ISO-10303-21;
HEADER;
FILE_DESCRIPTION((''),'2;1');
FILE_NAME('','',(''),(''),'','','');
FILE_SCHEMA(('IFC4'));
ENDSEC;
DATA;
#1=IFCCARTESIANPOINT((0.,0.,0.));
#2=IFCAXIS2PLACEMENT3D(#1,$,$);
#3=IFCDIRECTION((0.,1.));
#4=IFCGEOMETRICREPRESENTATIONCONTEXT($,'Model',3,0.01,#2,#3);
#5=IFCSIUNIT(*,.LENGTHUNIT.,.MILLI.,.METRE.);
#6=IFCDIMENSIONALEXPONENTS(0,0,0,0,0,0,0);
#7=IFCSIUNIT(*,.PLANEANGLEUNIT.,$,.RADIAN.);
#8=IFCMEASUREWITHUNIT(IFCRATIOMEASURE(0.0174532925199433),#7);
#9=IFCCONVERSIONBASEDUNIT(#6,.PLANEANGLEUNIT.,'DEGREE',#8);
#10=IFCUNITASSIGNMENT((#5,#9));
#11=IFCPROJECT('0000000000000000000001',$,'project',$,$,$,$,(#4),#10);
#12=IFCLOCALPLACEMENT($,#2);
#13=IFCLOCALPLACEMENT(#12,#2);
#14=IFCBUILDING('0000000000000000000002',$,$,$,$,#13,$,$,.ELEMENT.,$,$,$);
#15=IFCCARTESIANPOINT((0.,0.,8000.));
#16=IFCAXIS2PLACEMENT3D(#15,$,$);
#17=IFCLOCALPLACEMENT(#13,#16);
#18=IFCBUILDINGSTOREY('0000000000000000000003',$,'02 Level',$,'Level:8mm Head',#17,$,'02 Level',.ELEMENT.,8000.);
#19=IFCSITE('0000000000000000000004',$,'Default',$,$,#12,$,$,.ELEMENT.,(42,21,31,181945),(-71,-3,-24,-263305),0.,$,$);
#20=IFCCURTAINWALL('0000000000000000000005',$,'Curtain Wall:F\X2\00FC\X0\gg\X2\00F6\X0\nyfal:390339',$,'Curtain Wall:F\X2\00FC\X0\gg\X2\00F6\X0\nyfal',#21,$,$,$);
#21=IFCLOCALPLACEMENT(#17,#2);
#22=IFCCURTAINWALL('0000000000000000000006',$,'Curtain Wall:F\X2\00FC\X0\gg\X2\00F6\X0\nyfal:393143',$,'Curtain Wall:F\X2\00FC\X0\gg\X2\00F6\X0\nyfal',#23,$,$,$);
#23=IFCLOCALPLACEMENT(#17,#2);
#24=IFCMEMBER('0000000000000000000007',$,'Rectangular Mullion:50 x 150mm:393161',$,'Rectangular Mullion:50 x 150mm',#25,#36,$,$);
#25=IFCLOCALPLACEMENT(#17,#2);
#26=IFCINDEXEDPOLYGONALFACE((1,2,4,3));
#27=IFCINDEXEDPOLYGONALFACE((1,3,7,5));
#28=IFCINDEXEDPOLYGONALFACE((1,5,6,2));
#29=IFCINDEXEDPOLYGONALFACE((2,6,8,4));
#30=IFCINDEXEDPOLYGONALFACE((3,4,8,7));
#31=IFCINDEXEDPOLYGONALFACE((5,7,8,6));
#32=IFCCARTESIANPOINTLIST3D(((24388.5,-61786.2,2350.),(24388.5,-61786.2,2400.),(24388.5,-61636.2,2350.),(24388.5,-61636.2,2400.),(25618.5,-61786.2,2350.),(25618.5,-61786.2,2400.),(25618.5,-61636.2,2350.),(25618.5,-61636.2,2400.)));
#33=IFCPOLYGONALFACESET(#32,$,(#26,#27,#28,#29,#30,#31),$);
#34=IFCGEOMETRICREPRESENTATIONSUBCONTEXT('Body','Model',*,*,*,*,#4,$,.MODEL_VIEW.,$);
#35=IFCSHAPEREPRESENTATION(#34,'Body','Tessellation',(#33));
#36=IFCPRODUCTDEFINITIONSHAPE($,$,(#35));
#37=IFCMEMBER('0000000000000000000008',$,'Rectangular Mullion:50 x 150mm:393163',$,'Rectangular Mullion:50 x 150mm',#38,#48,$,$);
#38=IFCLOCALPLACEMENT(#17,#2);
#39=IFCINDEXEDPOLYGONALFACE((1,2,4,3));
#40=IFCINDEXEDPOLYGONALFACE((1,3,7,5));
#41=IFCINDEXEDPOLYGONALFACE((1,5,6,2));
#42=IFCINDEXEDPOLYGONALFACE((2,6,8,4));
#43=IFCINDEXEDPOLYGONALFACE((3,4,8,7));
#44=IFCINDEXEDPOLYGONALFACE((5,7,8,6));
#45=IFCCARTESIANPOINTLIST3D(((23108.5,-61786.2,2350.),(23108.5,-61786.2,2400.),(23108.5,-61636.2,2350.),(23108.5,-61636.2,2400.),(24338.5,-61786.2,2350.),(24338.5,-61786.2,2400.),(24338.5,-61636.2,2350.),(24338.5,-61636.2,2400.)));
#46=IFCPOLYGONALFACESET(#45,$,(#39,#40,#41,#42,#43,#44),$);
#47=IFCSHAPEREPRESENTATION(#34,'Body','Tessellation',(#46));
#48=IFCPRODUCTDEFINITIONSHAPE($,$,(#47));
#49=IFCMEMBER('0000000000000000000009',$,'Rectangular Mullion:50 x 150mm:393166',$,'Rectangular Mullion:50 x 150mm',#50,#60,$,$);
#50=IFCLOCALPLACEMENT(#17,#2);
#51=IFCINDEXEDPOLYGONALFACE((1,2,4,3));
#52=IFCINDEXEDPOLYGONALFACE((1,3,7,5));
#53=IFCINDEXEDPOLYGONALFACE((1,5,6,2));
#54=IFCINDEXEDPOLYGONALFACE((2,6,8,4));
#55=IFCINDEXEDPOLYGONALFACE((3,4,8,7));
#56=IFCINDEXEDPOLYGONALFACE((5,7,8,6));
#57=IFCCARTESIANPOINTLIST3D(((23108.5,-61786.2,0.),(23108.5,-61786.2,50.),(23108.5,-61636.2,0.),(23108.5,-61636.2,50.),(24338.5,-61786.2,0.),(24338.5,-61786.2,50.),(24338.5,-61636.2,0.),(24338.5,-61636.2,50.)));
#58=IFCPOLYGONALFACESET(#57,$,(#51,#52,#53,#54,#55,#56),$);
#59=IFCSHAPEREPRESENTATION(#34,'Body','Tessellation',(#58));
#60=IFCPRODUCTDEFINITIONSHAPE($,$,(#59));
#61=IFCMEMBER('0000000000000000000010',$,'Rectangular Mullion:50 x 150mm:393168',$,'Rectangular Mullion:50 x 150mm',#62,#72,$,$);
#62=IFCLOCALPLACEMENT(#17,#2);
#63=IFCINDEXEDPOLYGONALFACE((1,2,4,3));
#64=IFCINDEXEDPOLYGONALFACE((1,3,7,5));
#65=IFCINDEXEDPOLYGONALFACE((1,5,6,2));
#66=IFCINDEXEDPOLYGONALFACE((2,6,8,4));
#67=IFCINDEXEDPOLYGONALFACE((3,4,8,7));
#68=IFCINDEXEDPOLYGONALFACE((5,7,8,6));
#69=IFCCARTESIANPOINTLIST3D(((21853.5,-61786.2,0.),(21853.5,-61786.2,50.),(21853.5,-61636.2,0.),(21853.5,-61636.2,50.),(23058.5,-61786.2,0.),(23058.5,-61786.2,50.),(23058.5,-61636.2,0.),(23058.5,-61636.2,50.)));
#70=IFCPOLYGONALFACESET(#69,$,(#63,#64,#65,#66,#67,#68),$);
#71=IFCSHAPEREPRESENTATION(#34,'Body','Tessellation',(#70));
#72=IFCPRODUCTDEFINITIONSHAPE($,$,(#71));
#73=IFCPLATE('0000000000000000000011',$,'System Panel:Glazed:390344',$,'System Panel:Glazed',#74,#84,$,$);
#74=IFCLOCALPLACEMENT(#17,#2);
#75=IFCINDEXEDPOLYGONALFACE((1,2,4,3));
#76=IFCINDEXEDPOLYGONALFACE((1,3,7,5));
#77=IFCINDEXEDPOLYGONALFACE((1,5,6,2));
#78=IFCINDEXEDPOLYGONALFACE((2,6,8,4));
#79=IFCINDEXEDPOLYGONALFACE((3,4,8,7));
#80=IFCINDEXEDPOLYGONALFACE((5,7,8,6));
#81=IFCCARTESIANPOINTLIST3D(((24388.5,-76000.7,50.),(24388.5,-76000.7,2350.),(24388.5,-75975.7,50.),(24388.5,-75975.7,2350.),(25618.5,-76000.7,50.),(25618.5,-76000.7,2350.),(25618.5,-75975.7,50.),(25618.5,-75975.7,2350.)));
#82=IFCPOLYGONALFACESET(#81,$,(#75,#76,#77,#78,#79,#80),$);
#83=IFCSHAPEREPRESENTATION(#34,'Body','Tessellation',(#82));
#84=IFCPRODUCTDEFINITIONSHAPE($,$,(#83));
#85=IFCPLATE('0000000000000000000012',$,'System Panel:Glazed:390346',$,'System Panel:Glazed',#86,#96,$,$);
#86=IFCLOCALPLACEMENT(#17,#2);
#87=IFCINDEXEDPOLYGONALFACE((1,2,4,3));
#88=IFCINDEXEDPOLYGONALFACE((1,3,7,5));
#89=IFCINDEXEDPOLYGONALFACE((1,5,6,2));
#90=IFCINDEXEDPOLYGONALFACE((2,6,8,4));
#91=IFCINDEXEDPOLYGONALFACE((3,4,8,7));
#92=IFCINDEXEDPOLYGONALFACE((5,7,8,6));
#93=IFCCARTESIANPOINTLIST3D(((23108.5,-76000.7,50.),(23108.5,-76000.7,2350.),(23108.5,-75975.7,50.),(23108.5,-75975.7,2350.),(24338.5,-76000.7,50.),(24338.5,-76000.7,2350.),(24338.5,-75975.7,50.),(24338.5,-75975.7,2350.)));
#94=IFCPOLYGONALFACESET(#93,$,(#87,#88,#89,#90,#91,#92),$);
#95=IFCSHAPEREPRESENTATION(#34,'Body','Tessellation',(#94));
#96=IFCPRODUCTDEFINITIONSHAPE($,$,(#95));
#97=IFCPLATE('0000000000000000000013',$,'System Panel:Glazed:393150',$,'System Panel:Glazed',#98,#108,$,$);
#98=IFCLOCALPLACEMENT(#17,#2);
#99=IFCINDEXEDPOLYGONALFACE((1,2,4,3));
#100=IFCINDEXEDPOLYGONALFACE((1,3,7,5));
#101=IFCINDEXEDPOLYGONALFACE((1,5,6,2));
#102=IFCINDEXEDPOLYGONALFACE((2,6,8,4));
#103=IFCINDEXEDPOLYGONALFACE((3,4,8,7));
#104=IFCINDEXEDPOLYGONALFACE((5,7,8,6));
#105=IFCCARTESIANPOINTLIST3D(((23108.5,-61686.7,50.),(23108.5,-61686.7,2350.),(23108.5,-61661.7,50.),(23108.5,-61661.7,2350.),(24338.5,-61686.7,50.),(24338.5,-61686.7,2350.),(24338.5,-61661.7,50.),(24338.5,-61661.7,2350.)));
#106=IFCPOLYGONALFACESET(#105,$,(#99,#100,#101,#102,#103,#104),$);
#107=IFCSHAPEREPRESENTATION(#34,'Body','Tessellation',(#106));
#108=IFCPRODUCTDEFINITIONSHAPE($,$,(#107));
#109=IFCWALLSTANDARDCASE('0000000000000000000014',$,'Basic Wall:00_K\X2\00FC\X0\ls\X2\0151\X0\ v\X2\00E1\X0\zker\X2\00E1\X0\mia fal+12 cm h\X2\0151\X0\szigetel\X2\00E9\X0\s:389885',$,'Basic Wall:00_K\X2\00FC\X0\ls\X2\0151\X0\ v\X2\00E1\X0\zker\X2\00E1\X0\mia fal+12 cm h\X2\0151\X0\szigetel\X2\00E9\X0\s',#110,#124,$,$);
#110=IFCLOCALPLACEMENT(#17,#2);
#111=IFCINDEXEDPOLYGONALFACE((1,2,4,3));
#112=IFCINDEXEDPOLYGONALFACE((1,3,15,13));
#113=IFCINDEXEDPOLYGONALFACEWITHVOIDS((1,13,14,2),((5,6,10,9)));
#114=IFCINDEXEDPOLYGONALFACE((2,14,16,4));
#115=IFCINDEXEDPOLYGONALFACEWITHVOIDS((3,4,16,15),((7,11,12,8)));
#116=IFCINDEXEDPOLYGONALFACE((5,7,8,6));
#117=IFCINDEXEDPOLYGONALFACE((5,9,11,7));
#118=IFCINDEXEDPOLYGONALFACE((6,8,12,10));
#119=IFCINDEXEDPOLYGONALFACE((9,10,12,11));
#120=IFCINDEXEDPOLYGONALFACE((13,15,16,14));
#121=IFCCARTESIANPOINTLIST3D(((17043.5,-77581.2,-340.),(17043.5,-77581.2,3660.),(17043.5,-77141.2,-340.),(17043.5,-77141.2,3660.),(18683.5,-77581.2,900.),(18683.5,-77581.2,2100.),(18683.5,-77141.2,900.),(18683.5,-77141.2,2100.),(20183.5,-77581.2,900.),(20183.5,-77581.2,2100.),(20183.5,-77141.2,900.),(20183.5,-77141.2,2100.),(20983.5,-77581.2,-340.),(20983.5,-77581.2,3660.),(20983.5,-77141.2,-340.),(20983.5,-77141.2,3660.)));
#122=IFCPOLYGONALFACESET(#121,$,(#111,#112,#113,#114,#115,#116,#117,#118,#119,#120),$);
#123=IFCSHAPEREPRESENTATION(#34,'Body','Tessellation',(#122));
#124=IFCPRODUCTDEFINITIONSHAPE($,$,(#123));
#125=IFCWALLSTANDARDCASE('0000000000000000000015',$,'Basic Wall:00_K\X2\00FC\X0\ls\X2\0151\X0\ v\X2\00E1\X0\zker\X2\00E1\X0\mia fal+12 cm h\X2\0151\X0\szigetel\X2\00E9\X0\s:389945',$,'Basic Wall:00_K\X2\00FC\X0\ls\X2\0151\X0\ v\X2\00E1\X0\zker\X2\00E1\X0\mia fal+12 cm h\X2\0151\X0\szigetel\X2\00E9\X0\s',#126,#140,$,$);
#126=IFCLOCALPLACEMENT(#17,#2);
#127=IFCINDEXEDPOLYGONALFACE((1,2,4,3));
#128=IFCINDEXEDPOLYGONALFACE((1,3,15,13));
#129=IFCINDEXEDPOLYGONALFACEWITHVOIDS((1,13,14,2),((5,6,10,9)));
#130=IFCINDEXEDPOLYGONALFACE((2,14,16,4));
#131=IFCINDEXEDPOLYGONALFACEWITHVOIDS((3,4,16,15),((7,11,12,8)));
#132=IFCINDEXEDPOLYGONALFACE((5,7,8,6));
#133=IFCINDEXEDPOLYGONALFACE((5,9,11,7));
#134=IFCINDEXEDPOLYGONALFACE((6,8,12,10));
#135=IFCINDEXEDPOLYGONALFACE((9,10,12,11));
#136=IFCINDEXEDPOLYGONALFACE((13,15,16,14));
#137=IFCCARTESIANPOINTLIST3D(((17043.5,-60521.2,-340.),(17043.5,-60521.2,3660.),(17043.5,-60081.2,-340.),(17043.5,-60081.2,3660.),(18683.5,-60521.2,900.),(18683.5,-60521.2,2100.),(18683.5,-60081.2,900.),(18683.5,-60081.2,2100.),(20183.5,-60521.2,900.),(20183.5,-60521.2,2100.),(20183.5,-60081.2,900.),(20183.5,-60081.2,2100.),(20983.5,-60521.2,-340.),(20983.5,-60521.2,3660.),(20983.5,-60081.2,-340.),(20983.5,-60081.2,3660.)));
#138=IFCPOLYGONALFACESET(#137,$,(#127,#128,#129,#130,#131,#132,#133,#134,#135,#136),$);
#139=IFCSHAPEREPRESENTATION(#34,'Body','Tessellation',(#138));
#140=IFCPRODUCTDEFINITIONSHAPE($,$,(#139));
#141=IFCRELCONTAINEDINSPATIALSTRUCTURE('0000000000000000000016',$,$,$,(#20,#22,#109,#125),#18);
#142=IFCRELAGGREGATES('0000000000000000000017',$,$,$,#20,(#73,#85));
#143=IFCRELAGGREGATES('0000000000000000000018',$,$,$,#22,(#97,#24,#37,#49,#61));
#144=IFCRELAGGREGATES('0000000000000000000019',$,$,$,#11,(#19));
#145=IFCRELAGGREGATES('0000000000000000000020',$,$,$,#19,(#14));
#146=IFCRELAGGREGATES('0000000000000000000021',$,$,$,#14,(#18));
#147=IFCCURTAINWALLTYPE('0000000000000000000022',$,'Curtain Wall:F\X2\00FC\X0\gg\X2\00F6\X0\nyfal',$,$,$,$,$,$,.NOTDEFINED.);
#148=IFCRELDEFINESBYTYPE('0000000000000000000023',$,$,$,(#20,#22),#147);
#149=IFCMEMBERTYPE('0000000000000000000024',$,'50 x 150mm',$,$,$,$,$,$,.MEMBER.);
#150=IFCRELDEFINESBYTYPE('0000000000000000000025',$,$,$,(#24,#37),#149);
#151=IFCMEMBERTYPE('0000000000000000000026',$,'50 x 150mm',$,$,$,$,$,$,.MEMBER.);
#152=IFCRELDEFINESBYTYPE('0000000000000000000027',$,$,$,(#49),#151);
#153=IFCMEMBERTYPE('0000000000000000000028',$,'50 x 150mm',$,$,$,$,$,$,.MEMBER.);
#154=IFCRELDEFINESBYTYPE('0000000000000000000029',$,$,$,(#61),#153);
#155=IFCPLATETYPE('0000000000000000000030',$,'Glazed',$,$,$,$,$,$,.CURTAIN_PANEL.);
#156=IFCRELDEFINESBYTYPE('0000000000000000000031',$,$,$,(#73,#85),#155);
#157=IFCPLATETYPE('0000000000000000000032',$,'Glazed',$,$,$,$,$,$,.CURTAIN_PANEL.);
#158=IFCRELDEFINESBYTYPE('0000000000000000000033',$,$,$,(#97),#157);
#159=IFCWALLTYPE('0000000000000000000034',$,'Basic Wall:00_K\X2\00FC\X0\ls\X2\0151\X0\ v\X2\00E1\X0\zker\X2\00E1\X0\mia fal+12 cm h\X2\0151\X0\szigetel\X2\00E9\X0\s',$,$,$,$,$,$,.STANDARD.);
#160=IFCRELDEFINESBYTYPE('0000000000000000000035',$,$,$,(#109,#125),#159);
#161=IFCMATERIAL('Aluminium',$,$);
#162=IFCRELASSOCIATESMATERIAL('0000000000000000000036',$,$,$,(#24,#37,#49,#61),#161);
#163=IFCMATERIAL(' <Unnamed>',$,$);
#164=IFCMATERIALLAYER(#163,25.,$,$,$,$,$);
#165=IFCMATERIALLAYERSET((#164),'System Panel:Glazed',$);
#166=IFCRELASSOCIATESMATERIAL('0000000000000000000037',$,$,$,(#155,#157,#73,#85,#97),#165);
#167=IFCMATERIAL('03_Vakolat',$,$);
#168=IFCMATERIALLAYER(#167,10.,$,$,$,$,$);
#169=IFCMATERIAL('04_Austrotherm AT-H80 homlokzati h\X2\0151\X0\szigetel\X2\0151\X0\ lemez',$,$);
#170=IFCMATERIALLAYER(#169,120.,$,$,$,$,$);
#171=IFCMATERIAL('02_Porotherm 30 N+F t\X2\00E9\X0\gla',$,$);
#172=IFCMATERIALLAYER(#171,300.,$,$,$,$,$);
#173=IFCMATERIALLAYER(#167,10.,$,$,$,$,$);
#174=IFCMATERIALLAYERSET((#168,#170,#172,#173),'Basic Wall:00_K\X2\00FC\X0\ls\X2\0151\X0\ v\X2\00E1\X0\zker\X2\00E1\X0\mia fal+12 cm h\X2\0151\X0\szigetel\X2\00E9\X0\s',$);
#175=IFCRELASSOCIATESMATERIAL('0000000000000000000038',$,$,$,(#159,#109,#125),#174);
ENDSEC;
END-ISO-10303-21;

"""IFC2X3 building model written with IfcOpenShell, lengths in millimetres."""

from ifc_helpers import new_model, entity, si_unit, converted_unit, direction, frame, frame_2d, origin, origin_2d_with_axis, place, context, subcontext, project, spatial, rectangle, extrude, source, transform, mapped, material, layer, layer_set, layer_usage, type_object, type_shapes, element, aggregate, save


model = new_model("IFC2X3")

# Units and contexts
model_context = context("Model", 3, precision=0.01, world=origin(), true_north=direction((0.0, 1.0)))
body_context = subcontext(model_context, "Body", "Model", "MODEL_VIEW")
ifc_project = project(units=[si_unit("LENGTHUNIT", "METRE", prefix="MILLI"), converted_unit("PLANEANGLEUNIT", "DEGREE", entity("IfcRatioMeasure", 0.0174532925199433), si_unit("PLANEANGLEUNIT", "RADIAN"), dimensions=[0, 0, 0, 0, 0, 0, 0])], contexts=[model_context])

# Site, building, storey
site_placement = place(None, origin())
site = spatial("IfcSite", under=ifc_project, at=site_placement, Name="Default", CompositionType="ELEMENT", RefLatitude=(42, 21, 31, 181945), RefLongitude=(-71, -3, -24, -263305), RefElevation=0.0)
building_placement = place(site_placement, origin())
building = spatial("IfcBuilding", under=site, at=building_placement, CompositionType="ELEMENT")
storey_placement = place(building_placement, frame((0.0, 0.0, 8000.0)))
storey = spatial("IfcBuildingStorey", under=building, at=storey_placement, Name="02 Level", ObjectType="Level:8mm Head", LongName="02 Level", CompositionType="ELEMENT", Elevation=8000.0)

# Curtain walls, members
curtain_wall_type = type_object("IfcCurtainWallType", Name="Curtain Wall:Függönyfal", PredefinedType="NOTDEFINED")
curtain_wall_1_placement = place(storey_placement, frame((0.0, 0.0, -8000.0)))
curtain_wall_1 = element("IfcCurtainWall", 1, at=curtain_wall_1_placement, inside=storey, type_object=curtain_wall_type, Name="Curtain Wall:Függönyfal:390339", ObjectType="Curtain Wall:Függönyfal")
ifc_material_1 = material(Name="Aluminium")
curtain_wall_2_placement = place(storey_placement, frame((0.0, 0.0, -8000.0)))
curtain_wall_2 = element("IfcCurtainWall", 2, at=curtain_wall_2_placement, inside=storey, type_object=curtain_wall_type, Name="Curtain Wall:Függönyfal:393143", ObjectType="Curtain Wall:Függönyfal")
member_type_1 = type_object("IfcMemberType", Name="50 x 150mm", PredefinedType="MEMBER")
shared_shape_1 = source(origin(), body_context, "Body", "SweptSolid", [
    extrude(rectangle(XDim=150.0, YDim=50.0, at=origin_2d_with_axis()), frame((-25.0, 0.0, -1230.0), z_axis=(0.0, 0.0, 1.0), x_axis=(0.0, -1.0, 0.0)), (0.0, 0.0, 1.0), 1230.0),
])
type_shapes(member_type_1, [shared_shape_1])
member_1_placement = place(storey_placement, frame((24388.5, -61711.2, 2400.0), z_axis=(-1.0, 0.0, 0.0), x_axis=(0.0, 0.0, 1.0)))
member_1 = element("IfcMember", 3, at=member_1_placement, type_object=member_type_1, material=ifc_material_1, Name="Rectangular Mullion:50 x 150mm:393161", ObjectType="Rectangular Mullion:50 x 150mm", context=body_context, shape_type="MappedRepresentation", body=[
    mapped(shared_shape_1, transform((0.0, 0.0, 0.0), scale=1.0)),
])
member_2_placement = place(storey_placement, frame((23108.5, -61711.2, 2400.0), z_axis=(-1.0, 0.0, 0.0), x_axis=(0.0, 0.0, 1.0)))
member_2 = element("IfcMember", 4, at=member_2_placement, type_object=member_type_1, material=ifc_material_1, Name="Rectangular Mullion:50 x 150mm:393163", ObjectType="Rectangular Mullion:50 x 150mm", context=body_context, shape_type="MappedRepresentation", body=[
    mapped(shared_shape_1, transform((0.0, 0.0, 0.0), scale=1.0)),
])
member_type_2 = type_object("IfcMemberType", Name="50 x 150mm", PredefinedType="MEMBER")
shared_shape_2 = source(origin(), body_context, "Body", "SweptSolid", [
    extrude(rectangle(XDim=150.0, YDim=50.0, at=origin_2d_with_axis()), frame((-25.0, 0.0, -1230.0), z_axis=(0.0, 0.0, 1.0), x_axis=(0.0, -1.0, 0.0)), (0.0, 0.0, 1.0), 1230.0),
])
type_shapes(member_type_2, [shared_shape_2])
member_3_placement = place(storey_placement, frame((24338.5, -61711.2, 0.0), z_axis=(1.0, 0.0, 0.0), x_axis=(0.0, 0.0, -1.0)))
member_3 = element("IfcMember", 5, at=member_3_placement, type_object=member_type_2, material=ifc_material_1, Name="Rectangular Mullion:50 x 150mm:393166", ObjectType="Rectangular Mullion:50 x 150mm", context=body_context, shape_type="MappedRepresentation", body=[
    mapped(shared_shape_2, transform((0.0, 0.0, 0.0), scale=1.0)),
])
member_type_3 = type_object("IfcMemberType", Name="50 x 150mm", PredefinedType="MEMBER")
shared_shape_3 = source(origin(), body_context, "Body", "SweptSolid", [
    extrude(rectangle(XDim=150.0, YDim=50.0, at=origin_2d_with_axis()), frame((-25.0, 0.0, -1205.0), z_axis=(0.0, 0.0, 1.0), x_axis=(0.0, -1.0, 0.0)), (0.0, 0.0, 1.0), 1205.0),
])
type_shapes(member_type_3, [shared_shape_3])
member_4_placement = place(storey_placement, frame((23058.5, -61711.2, 0.0), z_axis=(1.0, 0.0, 0.0), x_axis=(0.0, 0.0, -1.0)))
member_4 = element("IfcMember", 6, at=member_4_placement, type_object=member_type_3, material=ifc_material_1, Name="Rectangular Mullion:50 x 150mm:393168", ObjectType="Rectangular Mullion:50 x 150mm", context=body_context, shape_type="MappedRepresentation", body=[
    mapped(shared_shape_3, transform((0.0, 0.0, 0.0), scale=1.0)),
])

# Plates
ifc_material_2 = material(Name=" <Unnamed>")
ifc_layer_1 = layer(ifc_material_2, 25.0)
ifc_layer_set_1 = layer_set([ifc_layer_1], Name="System Panel:Glazed")
ifc_layer_usage_1 = layer_usage(ifc_layer_set_1, "AXIS3", "POSITIVE", 0.1)
plate_type_1 = type_object("IfcPlateType", Name="Glazed", PredefinedType="CURTAIN_PANEL", material=ifc_layer_set_1)
shared_shape_4 = source(origin(), body_context, "Body", "SweptSolid", [
    extrude(rectangle(XDim=25.0, YDim=1230.0, at=origin_2d_with_axis()), frame((615.0, 12.5, 0.0), z_axis=(0.0, 0.0, 1.0), x_axis=(0.0, 1.0, 0.0)), (0.0, 0.0, 1.0), 2300.0),
])
type_shapes(plate_type_1, [shared_shape_4])
plate_1_placement = place(curtain_wall_1_placement, frame((25618.5, -75975.7, 8050.0), z_axis=(0.0, 0.0, 1.0), x_axis=(-1.0, 0.0, 0.0)))
plate_1 = element("IfcPlate", 7, at=plate_1_placement, type_object=plate_type_1, material=ifc_layer_usage_1, Name="System Panel:Glazed:390344", ObjectType="System Panel:Glazed", context=body_context, shape_type="MappedRepresentation", body=[
    mapped(shared_shape_4, transform((0.0, 0.0, 0.0), scale=1.0)),
])
ifc_layer_usage_2 = layer_usage(ifc_layer_set_1, "AXIS3", "POSITIVE", 0.1)
plate_2_placement = place(curtain_wall_1_placement, frame((24338.5, -75975.7, 8050.0), z_axis=(0.0, 0.0, 1.0), x_axis=(-1.0, 0.0, 0.0)))
plate_2 = element("IfcPlate", 8, at=plate_2_placement, type_object=plate_type_1, material=ifc_layer_usage_2, Name="System Panel:Glazed:390346", ObjectType="System Panel:Glazed", context=body_context, shape_type="MappedRepresentation", body=[
    mapped(shared_shape_4, transform((0.0, 0.0, 0.0), scale=1.0)),
])
ifc_layer_usage_3 = layer_usage(ifc_layer_set_1, "AXIS3", "POSITIVE", 0.1)
plate_type_2 = type_object("IfcPlateType", Name="Glazed", PredefinedType="CURTAIN_PANEL", material=ifc_layer_set_1)
shared_shape_5 = source(origin(), body_context, "Body", "SweptSolid", [
    extrude(rectangle(XDim=25.0, YDim=1230.0, at=frame_2d((0.0, 0.0), x_axis=(1.0, 0.0))), frame((615.0, 12.5, 0.0), z_axis=(0.0, 0.0, 1.0), x_axis=(0.0, 1.0, 0.0)), (0.0, 0.0, 1.0), 2300.0),
])
type_shapes(plate_type_2, [shared_shape_5])
plate_3_placement = place(curtain_wall_2_placement, frame((24338.5, -61661.7, 8050.0), z_axis=(0.0, 0.0, 1.0), x_axis=(-1.0, 0.0, 0.0)))
plate_3 = element("IfcPlate", 9, at=plate_3_placement, type_object=plate_type_2, material=ifc_layer_usage_3, Name="System Panel:Glazed:393150", ObjectType="System Panel:Glazed", context=body_context, shape_type="MappedRepresentation", body=[
    mapped(shared_shape_5, transform((0.0, 0.0, 0.0), scale=1.0)),
])

# Walls, openings
ifc_material_3 = material(Name="03_Vakolat")
ifc_layer_2 = layer(ifc_material_3, 10.0)
ifc_material_4 = material(Name="04_Austrotherm AT-H80 homlokzati hőszigetelő lemez")
ifc_layer_3 = layer(ifc_material_4, 120.0)
ifc_material_5 = material(Name="02_Porotherm 30 N+F tégla")
ifc_layer_4 = layer(ifc_material_5, 300.0)
ifc_layer_5 = layer(ifc_material_3, 10.0)
ifc_layer_set_2 = layer_set([ifc_layer_2, ifc_layer_3, ifc_layer_4, ifc_layer_5], Name="Basic Wall:00_Külső vázkerámia fal+12 cm hőszigetelés")
ifc_layer_usage_4 = layer_usage(ifc_layer_set_2, "AXIS2", "NEGATIVE", 220.0)
wall_type_1 = type_object("IfcWallType", Name="Basic Wall:00_Külső vázkerámia fal+12 cm hőszigetelés", PredefinedType="STANDARD", material=ifc_layer_set_2)
wall_1_placement = place(storey_placement, frame((20983.5, -77361.2, -340.0), z_axis=(0.0, 0.0, 1.0), x_axis=(-1.0, 0.0, 0.0)))
wall_1 = element("IfcWallStandardCase", 10, at=wall_1_placement, inside=storey, type_object=wall_type_1, material=ifc_layer_usage_4, Name="Basic Wall:00_Külső vázkerámia fal+12 cm hőszigetelés:389885", ObjectType="Basic Wall:00_Külső vázkerámia fal+12 cm hőszigetelés", context=body_context, shape_type="SweptSolid", body=[
    extrude(rectangle(XDim=3940.0, YDim=440.0, at=frame_2d((1970.0, 0.0), x_axis=(-1.0, 0.0))), origin(), (0.0, 0.0, 1.0), 4000.0),
])
opening_1_placement = place(wall_1_placement, frame((2300.0, 1744.0, 1240.0), z_axis=(0.0, 0.0, 1.0), x_axis=(-1.0, 0.0, 0.0)))
element("IfcOpeningElement", 11, at=opening_1_placement, cuts=wall_1, ObjectType="Opening", context=body_context, shape_type="SweptSolid", body=[
    extrude(rectangle(XDim=1200.0, YDim=1500.0, at=frame_2d((0.0, 0.0), x_axis=(0.0, 1.0))), frame((750.0, 3048.0, 600.0), z_axis=(0.0, -1.0, 0.0), x_axis=(1.0, 0.0, 0.0)), (0.0, 0.0, 1.0), 3048.0),
])
ifc_layer_usage_5 = layer_usage(ifc_layer_set_2, "AXIS2", "POSITIVE", -220.0)
wall_2_placement = place(storey_placement, frame((20983.5, -60301.2, -340.0), z_axis=(0.0, 0.0, 1.0), x_axis=(-1.0, 0.0, 0.0)))
wall_2 = element("IfcWallStandardCase", 12, at=wall_2_placement, inside=storey, type_object=wall_type_1, material=ifc_layer_usage_5, Name="Basic Wall:00_Külső vázkerámia fal+12 cm hőszigetelés:389945", ObjectType="Basic Wall:00_Külső vázkerámia fal+12 cm hőszigetelés", context=body_context, shape_type="SweptSolid", body=[
    extrude(rectangle(XDim=3940.0, YDim=440.0, at=frame_2d((1970.0, 0.0), x_axis=(-1.0, 0.0))), origin(), (0.0, 0.0, 1.0), 4000.0),
])
opening_2_placement = place(wall_2_placement, frame((2300.0, 1304.0, 1240.0), z_axis=(0.0, 0.0, 1.0), x_axis=(-1.0, 0.0, 0.0)))
element("IfcOpeningElement", 13, at=opening_2_placement, cuts=wall_2, ObjectType="Opening", context=body_context, shape_type="SweptSolid", body=[
    extrude(rectangle(XDim=1200.0, YDim=1500.0, at=frame_2d((0.0, 0.0), x_axis=(0.0, 1.0))), frame((750.0, 3048.0, 600.0), z_axis=(0.0, -1.0, 0.0), x_axis=(1.0, 0.0, 0.0)), (0.0, 0.0, 1.0), 3048.0),
])

aggregate(curtain_wall_1, [plate_1, plate_2])
aggregate(curtain_wall_2, [plate_3, member_1, member_2, member_3, member_4])

save(model, "model.ifc")
